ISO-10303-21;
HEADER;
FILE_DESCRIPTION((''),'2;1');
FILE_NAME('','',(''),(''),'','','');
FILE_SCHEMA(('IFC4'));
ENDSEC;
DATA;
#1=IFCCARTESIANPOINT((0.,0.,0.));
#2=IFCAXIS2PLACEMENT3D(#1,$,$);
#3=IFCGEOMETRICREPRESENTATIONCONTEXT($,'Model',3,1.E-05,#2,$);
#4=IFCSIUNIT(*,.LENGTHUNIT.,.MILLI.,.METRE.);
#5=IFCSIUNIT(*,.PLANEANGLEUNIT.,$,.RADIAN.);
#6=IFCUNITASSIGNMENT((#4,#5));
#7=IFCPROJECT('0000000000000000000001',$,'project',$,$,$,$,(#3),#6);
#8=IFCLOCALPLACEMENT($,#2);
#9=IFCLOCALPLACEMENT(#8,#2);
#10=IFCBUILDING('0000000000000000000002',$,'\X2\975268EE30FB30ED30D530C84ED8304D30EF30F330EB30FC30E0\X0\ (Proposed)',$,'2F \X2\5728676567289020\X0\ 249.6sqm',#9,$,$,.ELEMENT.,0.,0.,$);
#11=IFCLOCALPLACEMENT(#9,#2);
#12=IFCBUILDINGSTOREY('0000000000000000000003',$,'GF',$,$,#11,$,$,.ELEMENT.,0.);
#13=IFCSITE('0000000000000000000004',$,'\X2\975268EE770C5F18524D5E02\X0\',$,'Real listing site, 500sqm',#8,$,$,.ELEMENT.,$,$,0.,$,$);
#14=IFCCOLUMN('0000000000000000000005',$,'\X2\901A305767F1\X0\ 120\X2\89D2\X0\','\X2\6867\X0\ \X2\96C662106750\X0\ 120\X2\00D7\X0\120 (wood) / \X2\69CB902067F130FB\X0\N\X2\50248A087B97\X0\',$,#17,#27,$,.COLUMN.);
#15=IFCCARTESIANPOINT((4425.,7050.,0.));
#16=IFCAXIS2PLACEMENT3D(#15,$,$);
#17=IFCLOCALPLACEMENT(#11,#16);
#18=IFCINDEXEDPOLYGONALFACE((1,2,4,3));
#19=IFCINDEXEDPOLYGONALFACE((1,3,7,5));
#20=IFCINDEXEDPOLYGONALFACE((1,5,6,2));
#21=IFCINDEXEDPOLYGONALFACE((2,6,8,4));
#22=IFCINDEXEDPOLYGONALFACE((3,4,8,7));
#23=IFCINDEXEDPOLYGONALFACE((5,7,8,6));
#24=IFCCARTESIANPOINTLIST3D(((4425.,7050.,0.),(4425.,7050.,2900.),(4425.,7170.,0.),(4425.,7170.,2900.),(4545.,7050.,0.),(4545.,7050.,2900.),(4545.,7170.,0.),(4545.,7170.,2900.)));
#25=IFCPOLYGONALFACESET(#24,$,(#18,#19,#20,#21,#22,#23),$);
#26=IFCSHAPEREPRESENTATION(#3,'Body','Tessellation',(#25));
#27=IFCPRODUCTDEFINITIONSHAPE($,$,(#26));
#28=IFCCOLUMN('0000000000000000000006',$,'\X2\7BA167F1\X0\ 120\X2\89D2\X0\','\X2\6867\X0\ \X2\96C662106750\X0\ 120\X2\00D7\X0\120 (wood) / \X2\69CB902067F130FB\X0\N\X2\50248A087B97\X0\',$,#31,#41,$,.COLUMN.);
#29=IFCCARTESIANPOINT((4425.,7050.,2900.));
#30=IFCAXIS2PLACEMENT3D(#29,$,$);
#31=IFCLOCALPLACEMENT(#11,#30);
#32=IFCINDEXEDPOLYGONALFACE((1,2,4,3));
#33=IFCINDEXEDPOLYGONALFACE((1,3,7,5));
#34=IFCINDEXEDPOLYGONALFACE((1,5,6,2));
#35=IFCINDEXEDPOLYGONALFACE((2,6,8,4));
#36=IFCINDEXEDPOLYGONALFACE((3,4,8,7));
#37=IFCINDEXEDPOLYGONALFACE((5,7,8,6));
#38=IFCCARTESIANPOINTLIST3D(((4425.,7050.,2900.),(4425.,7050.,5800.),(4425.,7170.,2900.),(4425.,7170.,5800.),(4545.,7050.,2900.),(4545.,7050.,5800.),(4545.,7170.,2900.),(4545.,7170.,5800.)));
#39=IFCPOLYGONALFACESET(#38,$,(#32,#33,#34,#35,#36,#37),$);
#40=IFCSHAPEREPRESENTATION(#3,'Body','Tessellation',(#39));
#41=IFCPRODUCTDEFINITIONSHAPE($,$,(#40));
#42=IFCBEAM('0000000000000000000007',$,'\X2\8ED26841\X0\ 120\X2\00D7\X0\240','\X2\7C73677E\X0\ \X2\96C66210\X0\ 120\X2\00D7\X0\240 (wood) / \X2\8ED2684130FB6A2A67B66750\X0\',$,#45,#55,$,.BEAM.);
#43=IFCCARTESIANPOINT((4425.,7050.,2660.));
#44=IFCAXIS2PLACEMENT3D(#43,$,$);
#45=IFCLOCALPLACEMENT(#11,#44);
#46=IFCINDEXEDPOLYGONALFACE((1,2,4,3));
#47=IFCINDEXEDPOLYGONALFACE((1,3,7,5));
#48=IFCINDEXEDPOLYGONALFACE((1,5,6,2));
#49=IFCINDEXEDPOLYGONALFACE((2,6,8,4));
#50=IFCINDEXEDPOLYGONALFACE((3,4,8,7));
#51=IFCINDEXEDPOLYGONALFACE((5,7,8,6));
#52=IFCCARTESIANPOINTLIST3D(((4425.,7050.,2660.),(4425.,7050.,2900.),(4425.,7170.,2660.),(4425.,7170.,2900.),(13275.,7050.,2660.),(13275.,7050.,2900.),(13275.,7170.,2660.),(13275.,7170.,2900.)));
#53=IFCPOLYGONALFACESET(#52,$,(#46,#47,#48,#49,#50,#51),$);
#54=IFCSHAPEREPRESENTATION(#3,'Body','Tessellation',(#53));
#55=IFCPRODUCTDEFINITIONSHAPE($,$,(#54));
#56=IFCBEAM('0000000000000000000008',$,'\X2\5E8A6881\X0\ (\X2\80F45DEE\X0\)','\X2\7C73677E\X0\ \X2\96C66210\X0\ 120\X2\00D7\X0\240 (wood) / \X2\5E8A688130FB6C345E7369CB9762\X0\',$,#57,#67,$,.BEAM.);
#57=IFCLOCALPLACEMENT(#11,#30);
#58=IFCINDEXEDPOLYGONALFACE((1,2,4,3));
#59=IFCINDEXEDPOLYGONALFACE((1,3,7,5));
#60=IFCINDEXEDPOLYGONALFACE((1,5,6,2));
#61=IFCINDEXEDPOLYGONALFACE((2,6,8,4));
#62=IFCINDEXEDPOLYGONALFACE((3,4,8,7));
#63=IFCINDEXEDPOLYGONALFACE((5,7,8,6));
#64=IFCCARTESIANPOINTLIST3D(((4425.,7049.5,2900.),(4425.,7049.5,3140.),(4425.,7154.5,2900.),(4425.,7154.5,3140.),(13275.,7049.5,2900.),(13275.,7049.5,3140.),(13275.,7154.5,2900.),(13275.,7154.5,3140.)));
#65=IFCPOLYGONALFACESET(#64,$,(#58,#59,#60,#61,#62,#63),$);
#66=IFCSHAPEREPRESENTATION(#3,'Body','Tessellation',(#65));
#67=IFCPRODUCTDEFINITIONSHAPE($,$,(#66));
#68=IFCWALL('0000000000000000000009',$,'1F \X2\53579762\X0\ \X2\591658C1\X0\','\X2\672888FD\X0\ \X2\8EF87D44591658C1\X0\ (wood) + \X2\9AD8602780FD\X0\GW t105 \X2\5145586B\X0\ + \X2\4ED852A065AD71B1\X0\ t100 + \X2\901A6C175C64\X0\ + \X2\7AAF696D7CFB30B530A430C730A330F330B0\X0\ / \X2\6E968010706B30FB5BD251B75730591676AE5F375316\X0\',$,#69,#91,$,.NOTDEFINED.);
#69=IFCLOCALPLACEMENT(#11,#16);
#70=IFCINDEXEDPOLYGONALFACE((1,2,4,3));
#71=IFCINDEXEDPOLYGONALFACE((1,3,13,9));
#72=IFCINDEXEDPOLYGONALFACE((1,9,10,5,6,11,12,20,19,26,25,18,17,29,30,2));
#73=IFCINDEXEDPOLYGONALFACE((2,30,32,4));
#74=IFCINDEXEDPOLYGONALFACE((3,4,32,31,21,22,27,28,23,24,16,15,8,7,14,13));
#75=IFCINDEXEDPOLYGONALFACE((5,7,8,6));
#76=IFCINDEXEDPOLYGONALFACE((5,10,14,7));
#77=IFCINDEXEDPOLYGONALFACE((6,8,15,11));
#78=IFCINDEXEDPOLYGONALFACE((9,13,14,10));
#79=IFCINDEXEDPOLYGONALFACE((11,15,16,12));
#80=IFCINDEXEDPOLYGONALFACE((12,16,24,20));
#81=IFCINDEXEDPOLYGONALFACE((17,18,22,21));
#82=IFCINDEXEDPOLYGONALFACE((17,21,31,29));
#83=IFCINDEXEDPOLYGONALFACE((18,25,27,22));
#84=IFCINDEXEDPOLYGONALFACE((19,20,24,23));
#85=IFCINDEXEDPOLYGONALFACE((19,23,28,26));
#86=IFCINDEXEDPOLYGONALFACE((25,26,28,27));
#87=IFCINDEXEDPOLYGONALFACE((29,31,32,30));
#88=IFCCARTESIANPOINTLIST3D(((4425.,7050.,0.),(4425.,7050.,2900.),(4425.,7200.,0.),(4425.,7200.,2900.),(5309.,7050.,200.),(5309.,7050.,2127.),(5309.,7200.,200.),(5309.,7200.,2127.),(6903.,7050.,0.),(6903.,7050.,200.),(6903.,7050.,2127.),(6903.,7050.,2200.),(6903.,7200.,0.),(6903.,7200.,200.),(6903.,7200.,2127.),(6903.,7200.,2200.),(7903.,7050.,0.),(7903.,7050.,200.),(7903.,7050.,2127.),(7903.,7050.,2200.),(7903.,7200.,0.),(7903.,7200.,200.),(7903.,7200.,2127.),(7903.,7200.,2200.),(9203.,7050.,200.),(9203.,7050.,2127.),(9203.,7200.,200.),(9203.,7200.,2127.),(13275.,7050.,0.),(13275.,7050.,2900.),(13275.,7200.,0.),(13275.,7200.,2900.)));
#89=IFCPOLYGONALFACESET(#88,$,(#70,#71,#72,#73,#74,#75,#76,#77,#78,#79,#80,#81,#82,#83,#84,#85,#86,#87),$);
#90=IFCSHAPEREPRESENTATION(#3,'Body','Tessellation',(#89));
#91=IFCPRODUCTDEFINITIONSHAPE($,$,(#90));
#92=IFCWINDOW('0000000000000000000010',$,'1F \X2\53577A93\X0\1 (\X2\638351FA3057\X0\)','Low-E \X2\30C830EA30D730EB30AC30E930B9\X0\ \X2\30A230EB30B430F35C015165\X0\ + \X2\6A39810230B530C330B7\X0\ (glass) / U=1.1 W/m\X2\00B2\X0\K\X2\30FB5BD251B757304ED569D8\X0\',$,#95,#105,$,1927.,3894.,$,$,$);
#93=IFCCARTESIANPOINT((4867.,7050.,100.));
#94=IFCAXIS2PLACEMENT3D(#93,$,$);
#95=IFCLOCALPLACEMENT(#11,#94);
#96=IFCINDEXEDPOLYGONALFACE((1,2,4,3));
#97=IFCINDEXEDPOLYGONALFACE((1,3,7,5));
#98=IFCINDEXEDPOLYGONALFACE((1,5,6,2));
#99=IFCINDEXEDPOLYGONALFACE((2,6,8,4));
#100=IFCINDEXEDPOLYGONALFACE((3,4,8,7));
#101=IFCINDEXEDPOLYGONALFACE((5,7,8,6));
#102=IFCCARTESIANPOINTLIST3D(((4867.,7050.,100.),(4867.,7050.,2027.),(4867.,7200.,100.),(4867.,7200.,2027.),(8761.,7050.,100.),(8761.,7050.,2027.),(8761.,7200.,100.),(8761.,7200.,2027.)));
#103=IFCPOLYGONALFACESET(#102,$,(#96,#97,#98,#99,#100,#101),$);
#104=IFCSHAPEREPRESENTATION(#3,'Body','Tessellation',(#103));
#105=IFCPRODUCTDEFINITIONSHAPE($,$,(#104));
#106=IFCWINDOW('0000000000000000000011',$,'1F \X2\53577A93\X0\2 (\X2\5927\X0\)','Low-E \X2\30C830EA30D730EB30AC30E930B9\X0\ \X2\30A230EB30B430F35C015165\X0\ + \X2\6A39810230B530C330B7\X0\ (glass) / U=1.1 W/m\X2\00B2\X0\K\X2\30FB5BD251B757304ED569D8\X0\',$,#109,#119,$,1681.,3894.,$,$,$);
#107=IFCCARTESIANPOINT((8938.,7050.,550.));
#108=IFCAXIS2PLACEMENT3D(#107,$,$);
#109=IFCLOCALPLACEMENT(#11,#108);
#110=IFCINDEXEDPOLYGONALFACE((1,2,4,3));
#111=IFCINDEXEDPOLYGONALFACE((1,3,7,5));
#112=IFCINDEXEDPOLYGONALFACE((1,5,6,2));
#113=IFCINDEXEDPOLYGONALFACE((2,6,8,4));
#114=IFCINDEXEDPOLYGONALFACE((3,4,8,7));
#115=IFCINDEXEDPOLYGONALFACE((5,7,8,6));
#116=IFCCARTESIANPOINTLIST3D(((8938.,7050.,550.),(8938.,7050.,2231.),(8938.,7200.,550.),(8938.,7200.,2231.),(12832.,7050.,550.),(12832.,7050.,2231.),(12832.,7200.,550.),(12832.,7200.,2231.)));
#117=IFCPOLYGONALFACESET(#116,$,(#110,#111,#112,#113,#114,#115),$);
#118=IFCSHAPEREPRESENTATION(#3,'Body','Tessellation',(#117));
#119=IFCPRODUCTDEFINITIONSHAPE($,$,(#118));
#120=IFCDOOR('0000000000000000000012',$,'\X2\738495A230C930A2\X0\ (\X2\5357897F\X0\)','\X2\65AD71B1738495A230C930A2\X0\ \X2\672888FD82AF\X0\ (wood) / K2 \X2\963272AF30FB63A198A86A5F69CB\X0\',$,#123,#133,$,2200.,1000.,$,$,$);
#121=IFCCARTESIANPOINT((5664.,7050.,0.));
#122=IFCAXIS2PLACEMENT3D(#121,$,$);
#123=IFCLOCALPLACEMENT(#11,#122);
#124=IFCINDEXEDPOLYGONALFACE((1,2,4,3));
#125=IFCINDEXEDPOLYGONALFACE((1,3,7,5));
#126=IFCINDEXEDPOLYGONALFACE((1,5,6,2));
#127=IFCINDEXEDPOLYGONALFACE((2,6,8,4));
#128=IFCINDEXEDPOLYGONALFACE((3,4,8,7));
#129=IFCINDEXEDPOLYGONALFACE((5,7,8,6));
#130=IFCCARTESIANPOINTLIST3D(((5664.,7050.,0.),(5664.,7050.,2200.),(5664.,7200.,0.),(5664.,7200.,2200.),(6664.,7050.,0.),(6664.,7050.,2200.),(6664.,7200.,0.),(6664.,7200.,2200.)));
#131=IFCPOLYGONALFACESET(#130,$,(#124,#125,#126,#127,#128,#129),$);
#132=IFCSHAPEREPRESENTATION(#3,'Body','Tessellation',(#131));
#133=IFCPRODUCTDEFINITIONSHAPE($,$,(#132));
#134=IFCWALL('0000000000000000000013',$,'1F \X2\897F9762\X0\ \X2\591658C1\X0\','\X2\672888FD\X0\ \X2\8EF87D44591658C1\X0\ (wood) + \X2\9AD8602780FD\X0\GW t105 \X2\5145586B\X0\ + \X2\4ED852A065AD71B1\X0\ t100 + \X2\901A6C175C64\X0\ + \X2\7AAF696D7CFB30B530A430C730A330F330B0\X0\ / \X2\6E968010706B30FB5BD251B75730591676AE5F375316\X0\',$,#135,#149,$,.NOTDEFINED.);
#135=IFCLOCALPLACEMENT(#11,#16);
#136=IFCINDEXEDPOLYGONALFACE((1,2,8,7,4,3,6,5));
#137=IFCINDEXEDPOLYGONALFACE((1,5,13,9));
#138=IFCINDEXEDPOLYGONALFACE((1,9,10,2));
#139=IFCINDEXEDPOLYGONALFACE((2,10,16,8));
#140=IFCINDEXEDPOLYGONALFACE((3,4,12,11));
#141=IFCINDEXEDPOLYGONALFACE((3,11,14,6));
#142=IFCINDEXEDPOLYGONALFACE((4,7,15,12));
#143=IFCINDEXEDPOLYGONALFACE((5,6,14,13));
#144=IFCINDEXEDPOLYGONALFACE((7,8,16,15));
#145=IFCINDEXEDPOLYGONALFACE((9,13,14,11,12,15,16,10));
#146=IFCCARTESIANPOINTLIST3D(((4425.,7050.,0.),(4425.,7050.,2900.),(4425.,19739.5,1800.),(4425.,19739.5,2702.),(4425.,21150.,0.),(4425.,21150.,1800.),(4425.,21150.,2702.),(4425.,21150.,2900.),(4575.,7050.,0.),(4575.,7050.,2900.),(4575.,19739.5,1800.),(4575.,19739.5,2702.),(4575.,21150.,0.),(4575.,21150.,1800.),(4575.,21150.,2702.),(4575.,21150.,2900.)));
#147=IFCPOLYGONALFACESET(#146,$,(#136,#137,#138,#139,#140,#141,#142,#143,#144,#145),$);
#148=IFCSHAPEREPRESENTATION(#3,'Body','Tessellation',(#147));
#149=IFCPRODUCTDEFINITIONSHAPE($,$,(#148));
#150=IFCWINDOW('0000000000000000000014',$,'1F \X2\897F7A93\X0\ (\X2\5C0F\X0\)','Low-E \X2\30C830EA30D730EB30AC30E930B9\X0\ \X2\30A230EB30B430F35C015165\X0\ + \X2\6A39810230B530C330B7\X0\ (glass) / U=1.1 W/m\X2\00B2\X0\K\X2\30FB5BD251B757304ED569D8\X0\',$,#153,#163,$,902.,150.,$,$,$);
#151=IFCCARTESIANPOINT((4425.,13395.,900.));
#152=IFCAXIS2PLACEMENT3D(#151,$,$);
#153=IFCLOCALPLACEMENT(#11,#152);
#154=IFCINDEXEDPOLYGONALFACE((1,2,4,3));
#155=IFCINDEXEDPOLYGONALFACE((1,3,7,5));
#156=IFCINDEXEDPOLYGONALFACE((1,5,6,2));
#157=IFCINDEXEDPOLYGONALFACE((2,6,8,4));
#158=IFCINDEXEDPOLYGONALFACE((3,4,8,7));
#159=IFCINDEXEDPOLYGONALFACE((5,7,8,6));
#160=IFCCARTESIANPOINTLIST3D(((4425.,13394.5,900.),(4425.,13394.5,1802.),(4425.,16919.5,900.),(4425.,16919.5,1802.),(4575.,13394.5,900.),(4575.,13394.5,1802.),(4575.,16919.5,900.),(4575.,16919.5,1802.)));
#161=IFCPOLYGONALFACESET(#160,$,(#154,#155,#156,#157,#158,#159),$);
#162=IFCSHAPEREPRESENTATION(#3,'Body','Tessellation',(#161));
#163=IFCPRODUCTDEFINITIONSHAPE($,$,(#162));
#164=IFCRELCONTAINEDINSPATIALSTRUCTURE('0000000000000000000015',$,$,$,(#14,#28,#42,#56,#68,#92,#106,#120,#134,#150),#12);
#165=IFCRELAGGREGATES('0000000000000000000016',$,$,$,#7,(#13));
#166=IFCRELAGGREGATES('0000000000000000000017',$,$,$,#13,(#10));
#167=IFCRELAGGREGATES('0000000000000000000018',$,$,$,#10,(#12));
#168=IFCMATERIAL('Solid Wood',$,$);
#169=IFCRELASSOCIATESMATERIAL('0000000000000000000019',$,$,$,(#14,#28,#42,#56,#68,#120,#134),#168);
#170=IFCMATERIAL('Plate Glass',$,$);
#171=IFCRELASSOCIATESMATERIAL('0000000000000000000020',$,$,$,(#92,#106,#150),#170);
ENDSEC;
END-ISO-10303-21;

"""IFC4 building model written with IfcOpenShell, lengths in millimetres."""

from ifc_helpers import new_model, si_unit, frame, frame_2d, origin, place, context, project, spatial, rectangle, extrude, material, element, fill, save


model = new_model("IFC4")

# Units and contexts
model_context = context("Model", 3, precision=1e-05, world=origin())
ifc_project = project(units=[si_unit("LENGTHUNIT", "METRE", prefix="MILLI"), si_unit("PLANEANGLEUNIT", "RADIAN")], contexts=[model_context])

# Site, building, storey
site_placement = place(None, origin())
site = spatial("IfcSite", under=ifc_project, at=site_placement, Name="青森県弘前市", ObjectType="Real listing site, 500sqm", CompositionType="ELEMENT", RefElevation=0.0)
building_placement = place(site_placement, origin())
building = spatial("IfcBuilding", under=site, at=building_placement, Name="青森・ロフト付きワンルーム (Proposed)", ObjectType="2F 在来木造 249.6sqm", CompositionType="ELEMENT", ElevationOfRefHeight=0.0, ElevationOfTerrain=0.0)
storey_placement = place(building_placement, origin())
storey = spatial("IfcBuildingStorey", under=building, at=storey_placement, Name="GF", CompositionType="ELEMENT", Elevation=0.0)

# Columns
ifc_material_1 = material(Name="Solid Wood")
column_1_placement = place(storey_placement, frame((4425.0, 7050.0, 0.0)))
element("IfcColumn", 1, at=column_1_placement, inside=storey, material=ifc_material_1, Name="通し柱 120角", Description="桧 集成材 120×120 (wood) / 構造柱・N値計算", PredefinedType="COLUMN", context=model_context, shape_type="SweptSolid", body=[
    extrude(rectangle(XDim=120.0, YDim=120.0, at=frame_2d((60.0, 60.0))), frame((4425.0, 7050.0, 0.0)), (0.0, 0.0, 1.0), 2900.0),
])
column_2_placement = place(storey_placement, frame((4425.0, 7050.0, 2900.0)))
element("IfcColumn", 2, at=column_2_placement, inside=storey, material=ifc_material_1, Name="管柱 120角", Description="桧 集成材 120×120 (wood) / 構造柱・N値計算", PredefinedType="COLUMN", context=model_context, shape_type="SweptSolid", body=[
    extrude(rectangle(XDim=120.0, YDim=120.0, at=frame_2d((60.0, 60.0))), frame((4425.0, 7050.0, 2900.0)), (0.0, 0.0, 1.0), 2900.0),
])

# Beams
beam_1_placement = place(storey_placement, frame((4425.0, 7050.0, 2660.0)))
element("IfcBeam", 3, at=beam_1_placement, inside=storey, material=ifc_material_1, Name="軒桁 120×240", Description="米松 集成 120×240 (wood) / 軒桁・横架材", PredefinedType="BEAM", context=model_context, shape_type="SweptSolid", body=[
    extrude(rectangle(XDim=8850.0, YDim=120.0, at=frame_2d((4425.0, 60.0))), frame((4425.0, 7050.0, 2660.0)), (0.0, 0.0, 1.0), 240.0),
])
beam_2_placement = place(storey_placement, frame((4425.0, 7050.0, 2900.0)))
element("IfcBeam", 4, at=beam_2_placement, inside=storey, material=ifc_material_1, Name="床梁 (胴差)", Description="米松 集成 120×240 (wood) / 床梁・水平構面", PredefinedType="BEAM", context=model_context, shape_type="SweptSolid", body=[
    extrude(rectangle(XDim=8850.0, YDim=105.0, at=frame_2d((4425.0, 52.0))), frame((4425.0, 7050.0, 2900.0)), (0.0, 0.0, 1.0), 240.0),
])

# Wall, openings, windows, door
wall_1_placement = place(storey_placement, frame((4425.0, 7050.0, 0.0)))
wall_1 = element("IfcWall", 5, at=wall_1_placement, inside=storey, material=ifc_material_1, Name="1F 南面 外壁", Description="木製 軸組外壁 (wood) + 高性能GW t105 充填 + 付加断熱 t100 + 通気層 + 窯業系サイディング / 準耐火・寒冷地外皮強化", PredefinedType="NOTDEFINED", context=model_context, shape_type="SweptSolid", body=[
    extrude(rectangle(XDim=8850.0, YDim=150.0, at=frame_2d((4425.0, 75.0))), frame((4425.0, 7050.0, 0.0)), (0.0, 0.0, 1.0), 2900.0),
])
opening_1_placement = place(storey_placement, frame((4867.0, 7050.0, 100.0)))
opening_1 = element("IfcOpeningElement", 6, at=opening_1_placement, cuts=wall_1, PredefinedType="NOTDEFINED", context=model_context, shape_type="SweptSolid", body=[
    extrude(rectangle(XDim=3894.0, YDim=150.0, at=frame_2d((1947.0, 75.0))), frame((4867.0, 7050.0, 100.0)), (0.0, 0.0, 1.0), 1927.0),
])
opening_2_placement = place(storey_placement, frame((8938.0, 7050.0, 550.0)))
opening_2 = element("IfcOpeningElement", 7, at=opening_2_placement, cuts=wall_1, PredefinedType="NOTDEFINED", context=model_context, shape_type="SweptSolid", body=[
    extrude(rectangle(XDim=3894.0, YDim=150.0, at=frame_2d((1947.0, 75.0))), frame((8938.0, 7050.0, 550.0)), (0.0, 0.0, 1.0), 1681.0),
])
opening_3_placement = place(storey_placement, frame((5664.0, 7050.0, 0.0)))
opening_3 = element("IfcOpeningElement", 8, at=opening_3_placement, cuts=wall_1, PredefinedType="NOTDEFINED", context=model_context, shape_type="SweptSolid", body=[
    extrude(rectangle(XDim=1000.0, YDim=150.0, at=frame_2d((500.0, 75.0))), frame((5664.0, 7050.0, 0.0)), (0.0, 0.0, 1.0), 2200.0),
])
ifc_material_2 = material(Name="Plate Glass")
window_1_placement = place(storey_placement, frame((4867.0, 7050.0, 100.0)))
window_1 = element("IfcWindow", 9, at=window_1_placement, inside=storey, material=ifc_material_2, Name="1F 南窓1 (掃出し)", Description="Low-E トリプルガラス アルゴン封入 + 樹脂サッシ (glass) / U=1.1 W/m²K・寒冷地仕様", OverallHeight=1927.0, OverallWidth=3894.0, context=model_context, shape_type="SweptSolid", body=[
    extrude(rectangle(XDim=3894.0, YDim=150.0, at=frame_2d((1947.0, 75.0))), frame((4867.0, 7050.0, 100.0)), (0.0, 0.0, 1.0), 1927.0),
])
fill(opening_1, window_1)
window_2_placement = place(storey_placement, frame((8938.0, 7050.0, 550.0)))
window_2 = element("IfcWindow", 10, at=window_2_placement, inside=storey, material=ifc_material_2, Name="1F 南窓2 (大)", Description="Low-E トリプルガラス アルゴン封入 + 樹脂サッシ (glass) / U=1.1 W/m²K・寒冷地仕様", OverallHeight=1681.0, OverallWidth=3894.0, context=model_context, shape_type="SweptSolid", body=[
    extrude(rectangle(XDim=3894.0, YDim=150.0, at=frame_2d((1947.0, 75.0))), frame((8938.0, 7050.0, 550.0)), (0.0, 0.0, 1.0), 1681.0),
])
fill(opening_2, window_2)
door_placement = place(storey_placement, frame((5664.0, 7050.0, 0.0)))
door = element("IfcDoor", 11, at=door_placement, inside=storey, material=ifc_material_1, Name="玄関ドア (南西)", Description="断熱玄関ドア 木製芯 (wood) / K2 防犯・採風機構", OverallHeight=2200.0, OverallWidth=1000.0, context=model_context, shape_type="SweptSolid", body=[
    extrude(rectangle(XDim=1000.0, YDim=150.0, at=frame_2d((500.0, 75.0))), frame((5664.0, 7050.0, 0.0)), (0.0, 0.0, 1.0), 2200.0),
])
fill(opening_3, door)

# Wall, opening, window
wall_2_placement = place(storey_placement, frame((4425.0, 7050.0, 0.0)))
wall_2 = element("IfcWall", 12, at=wall_2_placement, inside=storey, material=ifc_material_1, Name="1F 西面 外壁", Description="木製 軸組外壁 (wood) + 高性能GW t105 充填 + 付加断熱 t100 + 通気層 + 窯業系サイディング / 準耐火・寒冷地外皮強化", PredefinedType="NOTDEFINED", context=model_context, shape_type="SweptSolid", body=[
    extrude(rectangle(XDim=150.0, YDim=14100.0, at=frame_2d((75.0, 7050.0))), frame((4425.0, 7050.0, 0.0)), (0.0, 0.0, 1.0), 2900.0),
])
opening_4_placement = place(storey_placement, frame((4425.0, 13395.0, 900.0)))
opening_4 = element("IfcOpeningElement", 13, at=opening_4_placement, cuts=wall_2, PredefinedType="NOTDEFINED", context=model_context, shape_type="SweptSolid", body=[
    extrude(rectangle(XDim=150.0, YDim=3525.0, at=frame_2d((75.0, 1762.0))), frame((4425.0, 13395.0, 900.0)), (0.0, 0.0, 1.0), 902.0),
])
window_3_placement = place(storey_placement, frame((4425.0, 13395.0, 900.0)))
window_3 = element("IfcWindow", 14, at=window_3_placement, inside=storey, material=ifc_material_2, Name="1F 西窓 (小)", Description="Low-E トリプルガラス アルゴン封入 + 樹脂サッシ (glass) / U=1.1 W/m²K・寒冷地仕様", OverallHeight=902.0, OverallWidth=150.0, context=model_context, shape_type="SweptSolid", body=[
    extrude(rectangle(XDim=150.0, YDim=3525.0, at=frame_2d((75.0, 1762.0))), frame((4425.0, 13395.0, 900.0)), (0.0, 0.0, 1.0), 902.0),
])
fill(opening_4, window_3)

save(model, "model.ifc")
